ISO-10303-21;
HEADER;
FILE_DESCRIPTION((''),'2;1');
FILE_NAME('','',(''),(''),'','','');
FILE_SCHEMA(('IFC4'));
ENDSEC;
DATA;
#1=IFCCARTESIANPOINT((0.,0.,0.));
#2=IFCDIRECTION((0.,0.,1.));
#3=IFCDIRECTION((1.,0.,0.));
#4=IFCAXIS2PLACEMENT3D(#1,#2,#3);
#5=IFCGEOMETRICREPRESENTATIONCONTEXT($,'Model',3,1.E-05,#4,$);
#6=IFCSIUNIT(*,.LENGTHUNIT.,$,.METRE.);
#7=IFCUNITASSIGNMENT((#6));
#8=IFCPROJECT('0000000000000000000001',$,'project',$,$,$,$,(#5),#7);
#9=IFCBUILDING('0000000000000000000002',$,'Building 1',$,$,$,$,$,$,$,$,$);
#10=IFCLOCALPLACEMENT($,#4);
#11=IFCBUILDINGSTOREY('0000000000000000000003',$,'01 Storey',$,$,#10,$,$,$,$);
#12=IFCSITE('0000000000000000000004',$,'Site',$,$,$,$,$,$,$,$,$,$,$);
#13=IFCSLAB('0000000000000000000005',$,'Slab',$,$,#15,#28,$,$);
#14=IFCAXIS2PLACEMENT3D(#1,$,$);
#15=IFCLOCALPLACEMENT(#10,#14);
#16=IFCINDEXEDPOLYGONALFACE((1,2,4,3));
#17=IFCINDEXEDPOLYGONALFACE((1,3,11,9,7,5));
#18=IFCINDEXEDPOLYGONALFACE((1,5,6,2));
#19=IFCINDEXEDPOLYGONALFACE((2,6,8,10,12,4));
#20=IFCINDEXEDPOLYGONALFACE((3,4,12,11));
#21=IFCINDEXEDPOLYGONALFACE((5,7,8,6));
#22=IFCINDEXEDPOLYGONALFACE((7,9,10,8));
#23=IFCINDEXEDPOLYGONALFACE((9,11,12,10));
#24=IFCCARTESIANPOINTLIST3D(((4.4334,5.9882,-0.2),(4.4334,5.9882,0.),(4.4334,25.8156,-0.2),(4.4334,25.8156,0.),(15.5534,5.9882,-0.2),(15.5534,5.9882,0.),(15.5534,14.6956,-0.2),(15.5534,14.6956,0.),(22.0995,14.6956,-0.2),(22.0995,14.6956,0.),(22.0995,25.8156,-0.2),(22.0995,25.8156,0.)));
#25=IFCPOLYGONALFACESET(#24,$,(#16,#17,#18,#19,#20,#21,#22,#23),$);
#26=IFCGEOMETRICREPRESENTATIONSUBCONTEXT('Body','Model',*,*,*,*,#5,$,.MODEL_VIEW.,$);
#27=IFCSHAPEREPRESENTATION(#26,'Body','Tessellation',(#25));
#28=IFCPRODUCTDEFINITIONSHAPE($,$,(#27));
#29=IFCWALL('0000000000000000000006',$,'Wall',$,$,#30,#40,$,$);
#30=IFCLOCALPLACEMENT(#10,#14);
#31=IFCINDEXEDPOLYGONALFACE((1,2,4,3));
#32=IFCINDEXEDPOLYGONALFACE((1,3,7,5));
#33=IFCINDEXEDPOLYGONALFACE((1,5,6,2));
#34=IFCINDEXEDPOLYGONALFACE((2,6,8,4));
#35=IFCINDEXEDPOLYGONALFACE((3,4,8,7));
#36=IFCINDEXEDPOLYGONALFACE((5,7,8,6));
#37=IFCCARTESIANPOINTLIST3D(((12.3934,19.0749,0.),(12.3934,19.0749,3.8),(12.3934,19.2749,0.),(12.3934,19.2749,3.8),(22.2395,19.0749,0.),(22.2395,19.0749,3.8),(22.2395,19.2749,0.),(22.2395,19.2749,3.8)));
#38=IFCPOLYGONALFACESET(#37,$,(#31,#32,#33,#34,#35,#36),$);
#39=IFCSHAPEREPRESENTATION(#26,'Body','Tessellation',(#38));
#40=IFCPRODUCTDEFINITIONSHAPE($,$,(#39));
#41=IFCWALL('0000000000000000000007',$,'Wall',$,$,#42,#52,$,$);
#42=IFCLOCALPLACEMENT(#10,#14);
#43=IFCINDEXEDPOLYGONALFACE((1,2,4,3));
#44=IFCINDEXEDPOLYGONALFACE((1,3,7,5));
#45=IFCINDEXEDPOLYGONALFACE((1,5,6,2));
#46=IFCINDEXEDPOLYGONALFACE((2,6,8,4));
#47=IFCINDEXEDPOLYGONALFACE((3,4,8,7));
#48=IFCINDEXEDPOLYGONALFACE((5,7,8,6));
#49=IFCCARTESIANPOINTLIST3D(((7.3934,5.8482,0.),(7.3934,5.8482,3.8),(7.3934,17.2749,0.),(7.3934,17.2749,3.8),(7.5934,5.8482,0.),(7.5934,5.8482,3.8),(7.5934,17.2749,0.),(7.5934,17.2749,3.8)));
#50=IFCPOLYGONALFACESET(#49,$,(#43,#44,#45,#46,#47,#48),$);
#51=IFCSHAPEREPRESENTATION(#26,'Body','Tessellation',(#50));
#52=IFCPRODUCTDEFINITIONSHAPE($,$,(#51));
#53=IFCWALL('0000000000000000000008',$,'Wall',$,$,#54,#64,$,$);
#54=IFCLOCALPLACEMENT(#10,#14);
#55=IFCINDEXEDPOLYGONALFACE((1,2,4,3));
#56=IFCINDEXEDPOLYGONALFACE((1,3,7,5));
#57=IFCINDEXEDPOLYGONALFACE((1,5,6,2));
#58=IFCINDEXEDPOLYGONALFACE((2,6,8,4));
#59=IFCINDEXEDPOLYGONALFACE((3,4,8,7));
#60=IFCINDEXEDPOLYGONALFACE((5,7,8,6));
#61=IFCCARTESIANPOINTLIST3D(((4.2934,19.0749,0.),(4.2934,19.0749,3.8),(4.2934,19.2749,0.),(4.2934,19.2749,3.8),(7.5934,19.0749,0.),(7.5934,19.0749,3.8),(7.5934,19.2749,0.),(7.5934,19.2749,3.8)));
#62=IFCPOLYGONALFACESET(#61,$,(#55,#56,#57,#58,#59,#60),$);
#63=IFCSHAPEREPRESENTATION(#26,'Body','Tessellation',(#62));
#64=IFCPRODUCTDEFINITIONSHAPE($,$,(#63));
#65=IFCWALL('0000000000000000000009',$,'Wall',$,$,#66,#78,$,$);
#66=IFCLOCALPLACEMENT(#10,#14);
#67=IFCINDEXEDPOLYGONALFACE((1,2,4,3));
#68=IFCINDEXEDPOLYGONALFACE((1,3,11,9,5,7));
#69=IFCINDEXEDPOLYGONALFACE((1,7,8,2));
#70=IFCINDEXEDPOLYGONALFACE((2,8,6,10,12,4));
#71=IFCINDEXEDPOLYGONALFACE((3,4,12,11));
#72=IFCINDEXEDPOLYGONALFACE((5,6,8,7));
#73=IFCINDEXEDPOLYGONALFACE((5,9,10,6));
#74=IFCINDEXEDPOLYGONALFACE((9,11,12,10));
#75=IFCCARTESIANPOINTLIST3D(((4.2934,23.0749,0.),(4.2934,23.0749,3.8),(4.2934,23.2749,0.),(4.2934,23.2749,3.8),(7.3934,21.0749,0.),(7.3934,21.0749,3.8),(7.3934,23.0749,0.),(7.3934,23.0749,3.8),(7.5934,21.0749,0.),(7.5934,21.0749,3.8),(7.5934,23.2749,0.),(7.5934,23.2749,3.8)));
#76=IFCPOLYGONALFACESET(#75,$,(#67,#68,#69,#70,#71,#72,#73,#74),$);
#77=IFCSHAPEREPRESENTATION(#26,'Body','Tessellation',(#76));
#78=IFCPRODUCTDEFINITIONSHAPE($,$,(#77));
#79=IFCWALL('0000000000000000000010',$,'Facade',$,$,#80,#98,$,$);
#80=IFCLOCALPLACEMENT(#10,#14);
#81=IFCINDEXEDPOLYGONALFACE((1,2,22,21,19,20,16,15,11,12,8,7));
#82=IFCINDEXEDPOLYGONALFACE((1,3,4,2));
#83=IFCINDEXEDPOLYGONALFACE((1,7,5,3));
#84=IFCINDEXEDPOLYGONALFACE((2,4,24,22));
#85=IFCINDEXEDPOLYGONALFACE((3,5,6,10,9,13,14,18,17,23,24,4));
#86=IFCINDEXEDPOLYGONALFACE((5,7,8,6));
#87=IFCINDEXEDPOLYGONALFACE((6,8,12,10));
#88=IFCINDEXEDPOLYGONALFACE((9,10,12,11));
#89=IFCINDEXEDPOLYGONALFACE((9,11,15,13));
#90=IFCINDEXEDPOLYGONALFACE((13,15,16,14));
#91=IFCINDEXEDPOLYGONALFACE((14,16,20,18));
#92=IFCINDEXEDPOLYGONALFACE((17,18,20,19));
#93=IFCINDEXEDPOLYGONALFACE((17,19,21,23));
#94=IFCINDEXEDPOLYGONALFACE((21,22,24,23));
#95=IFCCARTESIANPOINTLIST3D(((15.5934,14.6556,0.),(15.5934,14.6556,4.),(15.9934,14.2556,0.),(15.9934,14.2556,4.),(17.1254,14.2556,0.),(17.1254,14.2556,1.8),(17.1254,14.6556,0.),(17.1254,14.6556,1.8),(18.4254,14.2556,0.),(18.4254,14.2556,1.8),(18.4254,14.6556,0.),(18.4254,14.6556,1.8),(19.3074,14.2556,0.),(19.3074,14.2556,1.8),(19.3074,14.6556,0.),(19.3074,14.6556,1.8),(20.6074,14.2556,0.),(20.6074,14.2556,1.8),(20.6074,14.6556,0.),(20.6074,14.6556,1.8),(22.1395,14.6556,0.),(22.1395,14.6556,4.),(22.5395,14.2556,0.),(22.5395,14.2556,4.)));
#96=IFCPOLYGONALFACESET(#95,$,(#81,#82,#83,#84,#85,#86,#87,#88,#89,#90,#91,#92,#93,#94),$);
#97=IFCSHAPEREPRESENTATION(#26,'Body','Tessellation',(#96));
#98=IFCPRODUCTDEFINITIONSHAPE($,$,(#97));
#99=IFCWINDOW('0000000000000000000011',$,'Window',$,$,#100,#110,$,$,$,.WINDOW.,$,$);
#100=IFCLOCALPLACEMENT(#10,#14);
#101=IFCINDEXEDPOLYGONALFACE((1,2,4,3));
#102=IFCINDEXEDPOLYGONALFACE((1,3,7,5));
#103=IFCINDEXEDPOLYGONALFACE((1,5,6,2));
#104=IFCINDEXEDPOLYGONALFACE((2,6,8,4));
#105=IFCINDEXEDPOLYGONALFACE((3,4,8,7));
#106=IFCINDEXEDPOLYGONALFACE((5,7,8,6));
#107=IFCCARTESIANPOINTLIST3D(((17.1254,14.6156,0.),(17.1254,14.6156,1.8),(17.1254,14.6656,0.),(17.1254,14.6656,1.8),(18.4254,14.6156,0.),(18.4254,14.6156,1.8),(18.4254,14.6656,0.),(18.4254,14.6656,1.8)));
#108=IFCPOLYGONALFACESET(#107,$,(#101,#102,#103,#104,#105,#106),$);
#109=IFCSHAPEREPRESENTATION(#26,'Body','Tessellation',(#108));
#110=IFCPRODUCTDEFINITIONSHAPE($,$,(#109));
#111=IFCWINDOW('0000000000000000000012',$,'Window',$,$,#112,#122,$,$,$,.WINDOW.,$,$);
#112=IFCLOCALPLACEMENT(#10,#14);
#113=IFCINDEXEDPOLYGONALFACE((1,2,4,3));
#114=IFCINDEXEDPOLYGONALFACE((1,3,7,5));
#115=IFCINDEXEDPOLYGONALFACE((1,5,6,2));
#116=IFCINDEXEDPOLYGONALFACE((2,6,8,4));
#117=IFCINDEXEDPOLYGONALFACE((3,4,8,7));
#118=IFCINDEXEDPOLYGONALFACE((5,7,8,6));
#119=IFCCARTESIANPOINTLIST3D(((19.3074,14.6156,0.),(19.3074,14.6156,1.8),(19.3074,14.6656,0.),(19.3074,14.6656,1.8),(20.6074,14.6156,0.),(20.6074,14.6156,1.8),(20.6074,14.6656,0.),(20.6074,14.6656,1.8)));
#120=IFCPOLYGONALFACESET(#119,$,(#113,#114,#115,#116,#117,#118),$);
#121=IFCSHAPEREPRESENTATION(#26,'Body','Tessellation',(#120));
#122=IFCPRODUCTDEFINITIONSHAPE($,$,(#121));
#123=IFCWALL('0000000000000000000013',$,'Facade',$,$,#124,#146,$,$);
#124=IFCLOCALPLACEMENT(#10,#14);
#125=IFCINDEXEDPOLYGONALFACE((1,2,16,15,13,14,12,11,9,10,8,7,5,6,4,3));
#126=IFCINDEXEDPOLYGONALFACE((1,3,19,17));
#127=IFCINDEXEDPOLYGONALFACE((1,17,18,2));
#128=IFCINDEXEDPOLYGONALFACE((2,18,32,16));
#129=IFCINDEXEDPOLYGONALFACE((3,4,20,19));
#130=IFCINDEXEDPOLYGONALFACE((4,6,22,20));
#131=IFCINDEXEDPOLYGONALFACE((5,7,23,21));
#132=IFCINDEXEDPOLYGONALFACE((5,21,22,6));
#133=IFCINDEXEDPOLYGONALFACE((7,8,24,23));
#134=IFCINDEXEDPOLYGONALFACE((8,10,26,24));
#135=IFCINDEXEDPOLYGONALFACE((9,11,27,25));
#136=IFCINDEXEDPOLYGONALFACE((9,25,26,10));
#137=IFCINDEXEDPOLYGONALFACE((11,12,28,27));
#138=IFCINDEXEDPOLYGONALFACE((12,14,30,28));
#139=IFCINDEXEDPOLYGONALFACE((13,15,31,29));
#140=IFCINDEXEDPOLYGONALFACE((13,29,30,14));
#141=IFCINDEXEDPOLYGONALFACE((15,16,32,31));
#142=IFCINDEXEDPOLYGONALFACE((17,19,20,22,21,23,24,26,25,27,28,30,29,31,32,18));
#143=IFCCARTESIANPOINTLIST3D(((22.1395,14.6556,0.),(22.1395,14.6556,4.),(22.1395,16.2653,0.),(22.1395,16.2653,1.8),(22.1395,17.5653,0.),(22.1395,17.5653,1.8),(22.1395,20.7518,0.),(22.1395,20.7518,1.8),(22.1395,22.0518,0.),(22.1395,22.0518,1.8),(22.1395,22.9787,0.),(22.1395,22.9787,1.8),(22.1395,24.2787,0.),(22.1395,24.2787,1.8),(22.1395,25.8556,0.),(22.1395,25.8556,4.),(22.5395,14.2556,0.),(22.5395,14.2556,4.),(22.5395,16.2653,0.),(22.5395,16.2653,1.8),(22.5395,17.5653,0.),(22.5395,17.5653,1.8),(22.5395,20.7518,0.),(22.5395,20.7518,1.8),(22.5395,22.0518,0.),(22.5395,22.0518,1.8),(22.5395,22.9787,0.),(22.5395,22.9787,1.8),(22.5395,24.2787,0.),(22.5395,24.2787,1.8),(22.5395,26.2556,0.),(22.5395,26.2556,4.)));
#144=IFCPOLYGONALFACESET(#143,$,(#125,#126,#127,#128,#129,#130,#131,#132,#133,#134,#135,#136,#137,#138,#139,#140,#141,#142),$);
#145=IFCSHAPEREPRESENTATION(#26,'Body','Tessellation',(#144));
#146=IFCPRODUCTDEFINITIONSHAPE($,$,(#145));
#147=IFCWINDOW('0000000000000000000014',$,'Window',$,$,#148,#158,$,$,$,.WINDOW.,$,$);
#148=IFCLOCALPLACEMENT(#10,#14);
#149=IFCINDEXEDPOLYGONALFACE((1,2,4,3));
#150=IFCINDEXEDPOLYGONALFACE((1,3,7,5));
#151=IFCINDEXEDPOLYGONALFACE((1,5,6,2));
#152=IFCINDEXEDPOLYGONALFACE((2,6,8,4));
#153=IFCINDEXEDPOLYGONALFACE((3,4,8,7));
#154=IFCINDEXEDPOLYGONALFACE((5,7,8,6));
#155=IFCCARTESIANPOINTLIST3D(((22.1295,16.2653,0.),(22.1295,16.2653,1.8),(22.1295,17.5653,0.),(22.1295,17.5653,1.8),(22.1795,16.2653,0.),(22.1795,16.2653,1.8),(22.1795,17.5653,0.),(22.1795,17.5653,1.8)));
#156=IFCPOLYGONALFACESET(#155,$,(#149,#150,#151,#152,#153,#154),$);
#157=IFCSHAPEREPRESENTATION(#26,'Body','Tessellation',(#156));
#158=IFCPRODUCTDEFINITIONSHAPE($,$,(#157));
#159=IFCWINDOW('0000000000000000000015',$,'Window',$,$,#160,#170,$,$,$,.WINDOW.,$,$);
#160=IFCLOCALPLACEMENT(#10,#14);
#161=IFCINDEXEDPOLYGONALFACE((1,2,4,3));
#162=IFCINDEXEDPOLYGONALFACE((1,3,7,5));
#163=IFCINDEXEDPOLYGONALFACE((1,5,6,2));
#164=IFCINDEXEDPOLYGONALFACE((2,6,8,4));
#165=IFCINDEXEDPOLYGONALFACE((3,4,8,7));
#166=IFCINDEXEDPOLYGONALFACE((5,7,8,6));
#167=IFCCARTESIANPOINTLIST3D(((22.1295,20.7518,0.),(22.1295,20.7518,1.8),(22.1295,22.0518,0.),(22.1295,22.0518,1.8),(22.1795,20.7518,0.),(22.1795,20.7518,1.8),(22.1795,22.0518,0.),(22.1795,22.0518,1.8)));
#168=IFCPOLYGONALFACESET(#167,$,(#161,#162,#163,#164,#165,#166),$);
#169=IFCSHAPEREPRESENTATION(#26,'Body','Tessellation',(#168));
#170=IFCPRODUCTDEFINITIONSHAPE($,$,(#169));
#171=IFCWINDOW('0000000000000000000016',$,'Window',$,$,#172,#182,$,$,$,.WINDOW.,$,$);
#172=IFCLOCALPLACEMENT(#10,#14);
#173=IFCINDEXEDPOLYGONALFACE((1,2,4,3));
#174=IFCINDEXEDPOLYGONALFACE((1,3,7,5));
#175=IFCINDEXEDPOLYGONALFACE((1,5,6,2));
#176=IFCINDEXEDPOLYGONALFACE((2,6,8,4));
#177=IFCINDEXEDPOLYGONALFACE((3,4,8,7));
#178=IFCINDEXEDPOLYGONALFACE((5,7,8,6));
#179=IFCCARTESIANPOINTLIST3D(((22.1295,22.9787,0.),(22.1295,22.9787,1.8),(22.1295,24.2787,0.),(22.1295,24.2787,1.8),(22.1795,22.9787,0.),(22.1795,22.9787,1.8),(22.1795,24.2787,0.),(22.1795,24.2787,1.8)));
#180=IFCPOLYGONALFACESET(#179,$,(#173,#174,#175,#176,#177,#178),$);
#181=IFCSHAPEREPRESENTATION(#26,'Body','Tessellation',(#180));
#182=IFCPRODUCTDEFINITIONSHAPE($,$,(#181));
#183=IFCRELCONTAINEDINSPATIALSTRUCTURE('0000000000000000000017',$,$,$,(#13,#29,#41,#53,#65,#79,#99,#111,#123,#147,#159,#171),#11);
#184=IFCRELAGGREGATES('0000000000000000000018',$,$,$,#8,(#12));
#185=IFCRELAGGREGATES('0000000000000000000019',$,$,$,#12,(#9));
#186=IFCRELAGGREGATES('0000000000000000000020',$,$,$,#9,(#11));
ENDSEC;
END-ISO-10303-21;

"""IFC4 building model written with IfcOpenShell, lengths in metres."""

from ifc_helpers import new_model, si_unit, origin_with_axes, place, context, subcontext, project, spatial, line, indexed_curve, outline, extrude, element, fill, save


model = new_model("IFC4")

# Units and contexts
model_context = context("Model", 3, precision=1e-05, world=origin_with_axes())
body_context = subcontext(model_context, "Body", "Model", "MODEL_VIEW")
ifc_project = project(units=[si_unit("LENGTHUNIT", "METRE")], contexts=[model_context])

# Site, building, storey
site = spatial("IfcSite", under=ifc_project, Name="Site")
building = spatial("IfcBuilding", under=site, Name="Building 1")
storey_placement = place(None, origin_with_axes())
storey = spatial("IfcBuildingStorey", under=building, at=storey_placement, Name="01 Storey")

# Slab
slab_placement = place(storey_placement, origin_with_axes())
element("IfcSlab", 1, at=slab_placement, inside=storey, Name="Slab", context=body_context, shape_type="SweptSolid", body=[
    extrude(outline(indexed_curve([(15.5534, 14.6956), (22.0995, 14.6956), (22.0995, 25.8156), (4.4334, 25.8156), (4.4334, 5.9882), (15.5534, 5.9882)], segments=[line(1, 2), line(2, 3), line(3, 4), line(4, 5), line(5, 6)])), origin_with_axes(), (0.0, 0.0, -1.0), 0.2),
])

# Walls
wall_1_placement = place(storey_placement, origin_with_axes())
element("IfcWall", 2, at=wall_1_placement, inside=storey, Name="Wall", context=body_context, shape_type="SweptSolid", body=[
    extrude(outline(indexed_curve([(22.2395, 19.2749), (12.3934, 19.2749), (12.3934, 19.0749), (22.2395, 19.0749)], segments=[line(1, 2), line(2, 3), line(3, 4)])), origin_with_axes(), (0.0, 0.0, 1.0), 3.8),
])
wall_2_placement = place(storey_placement, origin_with_axes())
element("IfcWall", 3, at=wall_2_placement, inside=storey, Name="Wall", context=body_context, shape_type="SweptSolid", body=[
    extrude(outline(indexed_curve([(7.5934, 17.2749), (7.3934, 17.2749), (7.3934, 5.8482), (7.5934, 5.8482)], segments=[line(1, 2), line(2, 3), line(3, 4)])), origin_with_axes(), (0.0, 0.0, 1.0), 3.8),
])
wall_3_placement = place(storey_placement, origin_with_axes())
element("IfcWall", 4, at=wall_3_placement, inside=storey, Name="Wall", context=body_context, shape_type="SweptSolid", body=[
    extrude(outline(indexed_curve([(7.5934, 19.2749), (4.2934, 19.2749), (4.2934, 19.0749), (7.5934, 19.0749)], segments=[line(1, 2), line(2, 3), line(3, 4)])), origin_with_axes(), (0.0, 0.0, 1.0), 3.8),
])
wall_4_placement = place(storey_placement, origin_with_axes())
element("IfcWall", 5, at=wall_4_placement, inside=storey, Name="Wall", context=body_context, shape_type="SweptSolid", body=[
    extrude(outline(indexed_curve([(7.5934, 23.2749), (4.2934, 23.2749), (4.2934, 23.0749), (7.3934, 23.0749), (7.3934, 21.0749), (7.5934, 21.0749)], segments=[line(1, 2), line(2, 3), line(3, 4), line(4, 5), line(5, 6)])), origin_with_axes(), (0.0, 0.0, 1.0), 3.8),
])

# Walls, openings, windows
wall_5_placement = place(storey_placement, origin_with_axes())
wall_5 = element("IfcWall", 6, at=wall_5_placement, inside=storey, Name="Facade", context=body_context, shape_type="SweptSolid", body=[
    extrude(outline(indexed_curve([(15.5934, 14.6556), (22.1395, 14.6556), (22.5395, 14.2556), (15.9934, 14.2556)], segments=[line(1, 2), line(2, 3), line(3, 4)])), origin_with_axes(), (0.0, 0.0, 1.0), 4.0),
])
opening_1_placement = place(wall_5_placement, origin_with_axes())
opening_1 = element("IfcOpeningElement", 7, at=opening_1_placement, cuts=wall_5, context=body_context, shape_type="SweptSolid", body=[
    extrude(outline(indexed_curve([(17.1254, 14.2156), (17.1254, 14.7156), (18.4254, 14.7156), (18.4254, 14.2156)], segments=[line(1, 2), line(2, 3), line(3, 4)])), origin_with_axes(), (0.0, 0.0, 1.0), 1.8),
])
opening_2_placement = place(wall_5_placement, origin_with_axes())
opening_2 = element("IfcOpeningElement", 8, at=opening_2_placement, cuts=wall_5, context=body_context, shape_type="SweptSolid", body=[
    extrude(outline(indexed_curve([(19.3074, 14.2156), (19.3074, 14.7156), (20.6074, 14.7156), (20.6074, 14.2156)], segments=[line(1, 2), line(2, 3), line(3, 4)])), origin_with_axes(), (0.0, 0.0, 1.0), 1.8),
])
window_1_placement = place(storey_placement, origin_with_axes())
window_1 = element("IfcWindow", 9, at=window_1_placement, inside=storey, Name="Window", PredefinedType="WINDOW", context=body_context, shape_type="SweptSolid", body=[
    extrude(outline(indexed_curve([(17.1254, 14.6156), (17.1254, 14.6656), (18.4254, 14.6656), (18.4254, 14.6156)], segments=[line(1, 2), line(2, 3), line(3, 4)])), origin_with_axes(), (0.0, 0.0, 1.0), 1.8),
])
fill(opening_1, window_1)
window_2_placement = place(storey_placement, origin_with_axes())
window_2 = element("IfcWindow", 10, at=window_2_placement, inside=storey, Name="Window", PredefinedType="WINDOW", context=body_context, shape_type="SweptSolid", body=[
    extrude(outline(indexed_curve([(19.3074, 14.6156), (19.3074, 14.6656), (20.6074, 14.6656), (20.6074, 14.6156)], segments=[line(1, 2), line(2, 3), line(3, 4)])), origin_with_axes(), (0.0, 0.0, 1.0), 1.8),
])
fill(opening_2, window_2)
wall_6_placement = place(storey_placement, origin_with_axes())
wall_6 = element("IfcWall", 11, at=wall_6_placement, inside=storey, Name="Facade", context=body_context, shape_type="SweptSolid", body=[
    extrude(outline(indexed_curve([(22.1395, 14.6556), (22.1395, 25.8556), (22.5395, 26.2556), (22.5395, 14.2556)], segments=[line(1, 2), line(2, 3), line(3, 4)])), origin_with_axes(), (0.0, 0.0, 1.0), 4.0),
])
opening_3_placement = place(wall_6_placement, origin_with_axes())
opening_3 = element("IfcOpeningElement", 12, at=opening_3_placement, cuts=wall_6, context=body_context, shape_type="SweptSolid", body=[
    extrude(outline(indexed_curve([(22.5795, 16.2653), (22.0795, 16.2653), (22.0795, 17.5653), (22.5795, 17.5653)], segments=[line(1, 2), line(2, 3), line(3, 4)])), origin_with_axes(), (0.0, 0.0, 1.0), 1.8),
])
opening_4_placement = place(wall_6_placement, origin_with_axes())
opening_4 = element("IfcOpeningElement", 13, at=opening_4_placement, cuts=wall_6, context=body_context, shape_type="SweptSolid", body=[
    extrude(outline(indexed_curve([(22.5795, 20.7518), (22.0795, 20.7518), (22.0795, 22.0518), (22.5795, 22.0518)], segments=[line(1, 2), line(2, 3), line(3, 4)])), origin_with_axes(), (0.0, 0.0, 1.0), 1.8),
])
opening_5_placement = place(wall_6_placement, origin_with_axes())
opening_5 = element("IfcOpeningElement", 14, at=opening_5_placement, cuts=wall_6, context=body_context, shape_type="SweptSolid", body=[
    extrude(outline(indexed_curve([(22.5795, 22.9787), (22.0795, 22.9787), (22.0795, 24.2787), (22.5795, 24.2787)], segments=[line(1, 2), line(2, 3), line(3, 4)])), origin_with_axes(), (0.0, 0.0, 1.0), 1.8),
])
window_3_placement = place(storey_placement, origin_with_axes())
window_3 = element("IfcWindow", 15, at=window_3_placement, inside=storey, Name="Window", PredefinedType="WINDOW", context=body_context, shape_type="SweptSolid", body=[
    extrude(outline(indexed_curve([(22.1795, 16.2653), (22.1295, 16.2653), (22.1295, 17.5653), (22.1795, 17.5653)], segments=[line(1, 2), line(2, 3), line(3, 4)])), origin_with_axes(), (0.0, 0.0, 1.0), 1.8),
])
fill(opening_3, window_3)
window_4_placement = place(storey_placement, origin_with_axes())
window_4 = element("IfcWindow", 16, at=window_4_placement, inside=storey, Name="Window", PredefinedType="WINDOW", context=body_context, shape_type="SweptSolid", body=[
    extrude(outline(indexed_curve([(22.1795, 20.7518), (22.1295, 20.7518), (22.1295, 22.0518), (22.1795, 22.0518)], segments=[line(1, 2), line(2, 3), line(3, 4)])), origin_with_axes(), (0.0, 0.0, 1.0), 1.8),
])
fill(opening_4, window_4)
window_5_placement = place(storey_placement, origin_with_axes())
window_5 = element("IfcWindow", 17, at=window_5_placement, inside=storey, Name="Window", PredefinedType="WINDOW", context=body_context, shape_type="SweptSolid", body=[
    extrude(outline(indexed_curve([(22.1795, 22.9787), (22.1295, 22.9787), (22.1295, 24.2787), (22.1795, 24.2787)], segments=[line(1, 2), line(2, 3), line(3, 4)])), origin_with_axes(), (0.0, 0.0, 1.0), 1.8),
])
fill(opening_5, window_5)

save(model, "model.ifc")
